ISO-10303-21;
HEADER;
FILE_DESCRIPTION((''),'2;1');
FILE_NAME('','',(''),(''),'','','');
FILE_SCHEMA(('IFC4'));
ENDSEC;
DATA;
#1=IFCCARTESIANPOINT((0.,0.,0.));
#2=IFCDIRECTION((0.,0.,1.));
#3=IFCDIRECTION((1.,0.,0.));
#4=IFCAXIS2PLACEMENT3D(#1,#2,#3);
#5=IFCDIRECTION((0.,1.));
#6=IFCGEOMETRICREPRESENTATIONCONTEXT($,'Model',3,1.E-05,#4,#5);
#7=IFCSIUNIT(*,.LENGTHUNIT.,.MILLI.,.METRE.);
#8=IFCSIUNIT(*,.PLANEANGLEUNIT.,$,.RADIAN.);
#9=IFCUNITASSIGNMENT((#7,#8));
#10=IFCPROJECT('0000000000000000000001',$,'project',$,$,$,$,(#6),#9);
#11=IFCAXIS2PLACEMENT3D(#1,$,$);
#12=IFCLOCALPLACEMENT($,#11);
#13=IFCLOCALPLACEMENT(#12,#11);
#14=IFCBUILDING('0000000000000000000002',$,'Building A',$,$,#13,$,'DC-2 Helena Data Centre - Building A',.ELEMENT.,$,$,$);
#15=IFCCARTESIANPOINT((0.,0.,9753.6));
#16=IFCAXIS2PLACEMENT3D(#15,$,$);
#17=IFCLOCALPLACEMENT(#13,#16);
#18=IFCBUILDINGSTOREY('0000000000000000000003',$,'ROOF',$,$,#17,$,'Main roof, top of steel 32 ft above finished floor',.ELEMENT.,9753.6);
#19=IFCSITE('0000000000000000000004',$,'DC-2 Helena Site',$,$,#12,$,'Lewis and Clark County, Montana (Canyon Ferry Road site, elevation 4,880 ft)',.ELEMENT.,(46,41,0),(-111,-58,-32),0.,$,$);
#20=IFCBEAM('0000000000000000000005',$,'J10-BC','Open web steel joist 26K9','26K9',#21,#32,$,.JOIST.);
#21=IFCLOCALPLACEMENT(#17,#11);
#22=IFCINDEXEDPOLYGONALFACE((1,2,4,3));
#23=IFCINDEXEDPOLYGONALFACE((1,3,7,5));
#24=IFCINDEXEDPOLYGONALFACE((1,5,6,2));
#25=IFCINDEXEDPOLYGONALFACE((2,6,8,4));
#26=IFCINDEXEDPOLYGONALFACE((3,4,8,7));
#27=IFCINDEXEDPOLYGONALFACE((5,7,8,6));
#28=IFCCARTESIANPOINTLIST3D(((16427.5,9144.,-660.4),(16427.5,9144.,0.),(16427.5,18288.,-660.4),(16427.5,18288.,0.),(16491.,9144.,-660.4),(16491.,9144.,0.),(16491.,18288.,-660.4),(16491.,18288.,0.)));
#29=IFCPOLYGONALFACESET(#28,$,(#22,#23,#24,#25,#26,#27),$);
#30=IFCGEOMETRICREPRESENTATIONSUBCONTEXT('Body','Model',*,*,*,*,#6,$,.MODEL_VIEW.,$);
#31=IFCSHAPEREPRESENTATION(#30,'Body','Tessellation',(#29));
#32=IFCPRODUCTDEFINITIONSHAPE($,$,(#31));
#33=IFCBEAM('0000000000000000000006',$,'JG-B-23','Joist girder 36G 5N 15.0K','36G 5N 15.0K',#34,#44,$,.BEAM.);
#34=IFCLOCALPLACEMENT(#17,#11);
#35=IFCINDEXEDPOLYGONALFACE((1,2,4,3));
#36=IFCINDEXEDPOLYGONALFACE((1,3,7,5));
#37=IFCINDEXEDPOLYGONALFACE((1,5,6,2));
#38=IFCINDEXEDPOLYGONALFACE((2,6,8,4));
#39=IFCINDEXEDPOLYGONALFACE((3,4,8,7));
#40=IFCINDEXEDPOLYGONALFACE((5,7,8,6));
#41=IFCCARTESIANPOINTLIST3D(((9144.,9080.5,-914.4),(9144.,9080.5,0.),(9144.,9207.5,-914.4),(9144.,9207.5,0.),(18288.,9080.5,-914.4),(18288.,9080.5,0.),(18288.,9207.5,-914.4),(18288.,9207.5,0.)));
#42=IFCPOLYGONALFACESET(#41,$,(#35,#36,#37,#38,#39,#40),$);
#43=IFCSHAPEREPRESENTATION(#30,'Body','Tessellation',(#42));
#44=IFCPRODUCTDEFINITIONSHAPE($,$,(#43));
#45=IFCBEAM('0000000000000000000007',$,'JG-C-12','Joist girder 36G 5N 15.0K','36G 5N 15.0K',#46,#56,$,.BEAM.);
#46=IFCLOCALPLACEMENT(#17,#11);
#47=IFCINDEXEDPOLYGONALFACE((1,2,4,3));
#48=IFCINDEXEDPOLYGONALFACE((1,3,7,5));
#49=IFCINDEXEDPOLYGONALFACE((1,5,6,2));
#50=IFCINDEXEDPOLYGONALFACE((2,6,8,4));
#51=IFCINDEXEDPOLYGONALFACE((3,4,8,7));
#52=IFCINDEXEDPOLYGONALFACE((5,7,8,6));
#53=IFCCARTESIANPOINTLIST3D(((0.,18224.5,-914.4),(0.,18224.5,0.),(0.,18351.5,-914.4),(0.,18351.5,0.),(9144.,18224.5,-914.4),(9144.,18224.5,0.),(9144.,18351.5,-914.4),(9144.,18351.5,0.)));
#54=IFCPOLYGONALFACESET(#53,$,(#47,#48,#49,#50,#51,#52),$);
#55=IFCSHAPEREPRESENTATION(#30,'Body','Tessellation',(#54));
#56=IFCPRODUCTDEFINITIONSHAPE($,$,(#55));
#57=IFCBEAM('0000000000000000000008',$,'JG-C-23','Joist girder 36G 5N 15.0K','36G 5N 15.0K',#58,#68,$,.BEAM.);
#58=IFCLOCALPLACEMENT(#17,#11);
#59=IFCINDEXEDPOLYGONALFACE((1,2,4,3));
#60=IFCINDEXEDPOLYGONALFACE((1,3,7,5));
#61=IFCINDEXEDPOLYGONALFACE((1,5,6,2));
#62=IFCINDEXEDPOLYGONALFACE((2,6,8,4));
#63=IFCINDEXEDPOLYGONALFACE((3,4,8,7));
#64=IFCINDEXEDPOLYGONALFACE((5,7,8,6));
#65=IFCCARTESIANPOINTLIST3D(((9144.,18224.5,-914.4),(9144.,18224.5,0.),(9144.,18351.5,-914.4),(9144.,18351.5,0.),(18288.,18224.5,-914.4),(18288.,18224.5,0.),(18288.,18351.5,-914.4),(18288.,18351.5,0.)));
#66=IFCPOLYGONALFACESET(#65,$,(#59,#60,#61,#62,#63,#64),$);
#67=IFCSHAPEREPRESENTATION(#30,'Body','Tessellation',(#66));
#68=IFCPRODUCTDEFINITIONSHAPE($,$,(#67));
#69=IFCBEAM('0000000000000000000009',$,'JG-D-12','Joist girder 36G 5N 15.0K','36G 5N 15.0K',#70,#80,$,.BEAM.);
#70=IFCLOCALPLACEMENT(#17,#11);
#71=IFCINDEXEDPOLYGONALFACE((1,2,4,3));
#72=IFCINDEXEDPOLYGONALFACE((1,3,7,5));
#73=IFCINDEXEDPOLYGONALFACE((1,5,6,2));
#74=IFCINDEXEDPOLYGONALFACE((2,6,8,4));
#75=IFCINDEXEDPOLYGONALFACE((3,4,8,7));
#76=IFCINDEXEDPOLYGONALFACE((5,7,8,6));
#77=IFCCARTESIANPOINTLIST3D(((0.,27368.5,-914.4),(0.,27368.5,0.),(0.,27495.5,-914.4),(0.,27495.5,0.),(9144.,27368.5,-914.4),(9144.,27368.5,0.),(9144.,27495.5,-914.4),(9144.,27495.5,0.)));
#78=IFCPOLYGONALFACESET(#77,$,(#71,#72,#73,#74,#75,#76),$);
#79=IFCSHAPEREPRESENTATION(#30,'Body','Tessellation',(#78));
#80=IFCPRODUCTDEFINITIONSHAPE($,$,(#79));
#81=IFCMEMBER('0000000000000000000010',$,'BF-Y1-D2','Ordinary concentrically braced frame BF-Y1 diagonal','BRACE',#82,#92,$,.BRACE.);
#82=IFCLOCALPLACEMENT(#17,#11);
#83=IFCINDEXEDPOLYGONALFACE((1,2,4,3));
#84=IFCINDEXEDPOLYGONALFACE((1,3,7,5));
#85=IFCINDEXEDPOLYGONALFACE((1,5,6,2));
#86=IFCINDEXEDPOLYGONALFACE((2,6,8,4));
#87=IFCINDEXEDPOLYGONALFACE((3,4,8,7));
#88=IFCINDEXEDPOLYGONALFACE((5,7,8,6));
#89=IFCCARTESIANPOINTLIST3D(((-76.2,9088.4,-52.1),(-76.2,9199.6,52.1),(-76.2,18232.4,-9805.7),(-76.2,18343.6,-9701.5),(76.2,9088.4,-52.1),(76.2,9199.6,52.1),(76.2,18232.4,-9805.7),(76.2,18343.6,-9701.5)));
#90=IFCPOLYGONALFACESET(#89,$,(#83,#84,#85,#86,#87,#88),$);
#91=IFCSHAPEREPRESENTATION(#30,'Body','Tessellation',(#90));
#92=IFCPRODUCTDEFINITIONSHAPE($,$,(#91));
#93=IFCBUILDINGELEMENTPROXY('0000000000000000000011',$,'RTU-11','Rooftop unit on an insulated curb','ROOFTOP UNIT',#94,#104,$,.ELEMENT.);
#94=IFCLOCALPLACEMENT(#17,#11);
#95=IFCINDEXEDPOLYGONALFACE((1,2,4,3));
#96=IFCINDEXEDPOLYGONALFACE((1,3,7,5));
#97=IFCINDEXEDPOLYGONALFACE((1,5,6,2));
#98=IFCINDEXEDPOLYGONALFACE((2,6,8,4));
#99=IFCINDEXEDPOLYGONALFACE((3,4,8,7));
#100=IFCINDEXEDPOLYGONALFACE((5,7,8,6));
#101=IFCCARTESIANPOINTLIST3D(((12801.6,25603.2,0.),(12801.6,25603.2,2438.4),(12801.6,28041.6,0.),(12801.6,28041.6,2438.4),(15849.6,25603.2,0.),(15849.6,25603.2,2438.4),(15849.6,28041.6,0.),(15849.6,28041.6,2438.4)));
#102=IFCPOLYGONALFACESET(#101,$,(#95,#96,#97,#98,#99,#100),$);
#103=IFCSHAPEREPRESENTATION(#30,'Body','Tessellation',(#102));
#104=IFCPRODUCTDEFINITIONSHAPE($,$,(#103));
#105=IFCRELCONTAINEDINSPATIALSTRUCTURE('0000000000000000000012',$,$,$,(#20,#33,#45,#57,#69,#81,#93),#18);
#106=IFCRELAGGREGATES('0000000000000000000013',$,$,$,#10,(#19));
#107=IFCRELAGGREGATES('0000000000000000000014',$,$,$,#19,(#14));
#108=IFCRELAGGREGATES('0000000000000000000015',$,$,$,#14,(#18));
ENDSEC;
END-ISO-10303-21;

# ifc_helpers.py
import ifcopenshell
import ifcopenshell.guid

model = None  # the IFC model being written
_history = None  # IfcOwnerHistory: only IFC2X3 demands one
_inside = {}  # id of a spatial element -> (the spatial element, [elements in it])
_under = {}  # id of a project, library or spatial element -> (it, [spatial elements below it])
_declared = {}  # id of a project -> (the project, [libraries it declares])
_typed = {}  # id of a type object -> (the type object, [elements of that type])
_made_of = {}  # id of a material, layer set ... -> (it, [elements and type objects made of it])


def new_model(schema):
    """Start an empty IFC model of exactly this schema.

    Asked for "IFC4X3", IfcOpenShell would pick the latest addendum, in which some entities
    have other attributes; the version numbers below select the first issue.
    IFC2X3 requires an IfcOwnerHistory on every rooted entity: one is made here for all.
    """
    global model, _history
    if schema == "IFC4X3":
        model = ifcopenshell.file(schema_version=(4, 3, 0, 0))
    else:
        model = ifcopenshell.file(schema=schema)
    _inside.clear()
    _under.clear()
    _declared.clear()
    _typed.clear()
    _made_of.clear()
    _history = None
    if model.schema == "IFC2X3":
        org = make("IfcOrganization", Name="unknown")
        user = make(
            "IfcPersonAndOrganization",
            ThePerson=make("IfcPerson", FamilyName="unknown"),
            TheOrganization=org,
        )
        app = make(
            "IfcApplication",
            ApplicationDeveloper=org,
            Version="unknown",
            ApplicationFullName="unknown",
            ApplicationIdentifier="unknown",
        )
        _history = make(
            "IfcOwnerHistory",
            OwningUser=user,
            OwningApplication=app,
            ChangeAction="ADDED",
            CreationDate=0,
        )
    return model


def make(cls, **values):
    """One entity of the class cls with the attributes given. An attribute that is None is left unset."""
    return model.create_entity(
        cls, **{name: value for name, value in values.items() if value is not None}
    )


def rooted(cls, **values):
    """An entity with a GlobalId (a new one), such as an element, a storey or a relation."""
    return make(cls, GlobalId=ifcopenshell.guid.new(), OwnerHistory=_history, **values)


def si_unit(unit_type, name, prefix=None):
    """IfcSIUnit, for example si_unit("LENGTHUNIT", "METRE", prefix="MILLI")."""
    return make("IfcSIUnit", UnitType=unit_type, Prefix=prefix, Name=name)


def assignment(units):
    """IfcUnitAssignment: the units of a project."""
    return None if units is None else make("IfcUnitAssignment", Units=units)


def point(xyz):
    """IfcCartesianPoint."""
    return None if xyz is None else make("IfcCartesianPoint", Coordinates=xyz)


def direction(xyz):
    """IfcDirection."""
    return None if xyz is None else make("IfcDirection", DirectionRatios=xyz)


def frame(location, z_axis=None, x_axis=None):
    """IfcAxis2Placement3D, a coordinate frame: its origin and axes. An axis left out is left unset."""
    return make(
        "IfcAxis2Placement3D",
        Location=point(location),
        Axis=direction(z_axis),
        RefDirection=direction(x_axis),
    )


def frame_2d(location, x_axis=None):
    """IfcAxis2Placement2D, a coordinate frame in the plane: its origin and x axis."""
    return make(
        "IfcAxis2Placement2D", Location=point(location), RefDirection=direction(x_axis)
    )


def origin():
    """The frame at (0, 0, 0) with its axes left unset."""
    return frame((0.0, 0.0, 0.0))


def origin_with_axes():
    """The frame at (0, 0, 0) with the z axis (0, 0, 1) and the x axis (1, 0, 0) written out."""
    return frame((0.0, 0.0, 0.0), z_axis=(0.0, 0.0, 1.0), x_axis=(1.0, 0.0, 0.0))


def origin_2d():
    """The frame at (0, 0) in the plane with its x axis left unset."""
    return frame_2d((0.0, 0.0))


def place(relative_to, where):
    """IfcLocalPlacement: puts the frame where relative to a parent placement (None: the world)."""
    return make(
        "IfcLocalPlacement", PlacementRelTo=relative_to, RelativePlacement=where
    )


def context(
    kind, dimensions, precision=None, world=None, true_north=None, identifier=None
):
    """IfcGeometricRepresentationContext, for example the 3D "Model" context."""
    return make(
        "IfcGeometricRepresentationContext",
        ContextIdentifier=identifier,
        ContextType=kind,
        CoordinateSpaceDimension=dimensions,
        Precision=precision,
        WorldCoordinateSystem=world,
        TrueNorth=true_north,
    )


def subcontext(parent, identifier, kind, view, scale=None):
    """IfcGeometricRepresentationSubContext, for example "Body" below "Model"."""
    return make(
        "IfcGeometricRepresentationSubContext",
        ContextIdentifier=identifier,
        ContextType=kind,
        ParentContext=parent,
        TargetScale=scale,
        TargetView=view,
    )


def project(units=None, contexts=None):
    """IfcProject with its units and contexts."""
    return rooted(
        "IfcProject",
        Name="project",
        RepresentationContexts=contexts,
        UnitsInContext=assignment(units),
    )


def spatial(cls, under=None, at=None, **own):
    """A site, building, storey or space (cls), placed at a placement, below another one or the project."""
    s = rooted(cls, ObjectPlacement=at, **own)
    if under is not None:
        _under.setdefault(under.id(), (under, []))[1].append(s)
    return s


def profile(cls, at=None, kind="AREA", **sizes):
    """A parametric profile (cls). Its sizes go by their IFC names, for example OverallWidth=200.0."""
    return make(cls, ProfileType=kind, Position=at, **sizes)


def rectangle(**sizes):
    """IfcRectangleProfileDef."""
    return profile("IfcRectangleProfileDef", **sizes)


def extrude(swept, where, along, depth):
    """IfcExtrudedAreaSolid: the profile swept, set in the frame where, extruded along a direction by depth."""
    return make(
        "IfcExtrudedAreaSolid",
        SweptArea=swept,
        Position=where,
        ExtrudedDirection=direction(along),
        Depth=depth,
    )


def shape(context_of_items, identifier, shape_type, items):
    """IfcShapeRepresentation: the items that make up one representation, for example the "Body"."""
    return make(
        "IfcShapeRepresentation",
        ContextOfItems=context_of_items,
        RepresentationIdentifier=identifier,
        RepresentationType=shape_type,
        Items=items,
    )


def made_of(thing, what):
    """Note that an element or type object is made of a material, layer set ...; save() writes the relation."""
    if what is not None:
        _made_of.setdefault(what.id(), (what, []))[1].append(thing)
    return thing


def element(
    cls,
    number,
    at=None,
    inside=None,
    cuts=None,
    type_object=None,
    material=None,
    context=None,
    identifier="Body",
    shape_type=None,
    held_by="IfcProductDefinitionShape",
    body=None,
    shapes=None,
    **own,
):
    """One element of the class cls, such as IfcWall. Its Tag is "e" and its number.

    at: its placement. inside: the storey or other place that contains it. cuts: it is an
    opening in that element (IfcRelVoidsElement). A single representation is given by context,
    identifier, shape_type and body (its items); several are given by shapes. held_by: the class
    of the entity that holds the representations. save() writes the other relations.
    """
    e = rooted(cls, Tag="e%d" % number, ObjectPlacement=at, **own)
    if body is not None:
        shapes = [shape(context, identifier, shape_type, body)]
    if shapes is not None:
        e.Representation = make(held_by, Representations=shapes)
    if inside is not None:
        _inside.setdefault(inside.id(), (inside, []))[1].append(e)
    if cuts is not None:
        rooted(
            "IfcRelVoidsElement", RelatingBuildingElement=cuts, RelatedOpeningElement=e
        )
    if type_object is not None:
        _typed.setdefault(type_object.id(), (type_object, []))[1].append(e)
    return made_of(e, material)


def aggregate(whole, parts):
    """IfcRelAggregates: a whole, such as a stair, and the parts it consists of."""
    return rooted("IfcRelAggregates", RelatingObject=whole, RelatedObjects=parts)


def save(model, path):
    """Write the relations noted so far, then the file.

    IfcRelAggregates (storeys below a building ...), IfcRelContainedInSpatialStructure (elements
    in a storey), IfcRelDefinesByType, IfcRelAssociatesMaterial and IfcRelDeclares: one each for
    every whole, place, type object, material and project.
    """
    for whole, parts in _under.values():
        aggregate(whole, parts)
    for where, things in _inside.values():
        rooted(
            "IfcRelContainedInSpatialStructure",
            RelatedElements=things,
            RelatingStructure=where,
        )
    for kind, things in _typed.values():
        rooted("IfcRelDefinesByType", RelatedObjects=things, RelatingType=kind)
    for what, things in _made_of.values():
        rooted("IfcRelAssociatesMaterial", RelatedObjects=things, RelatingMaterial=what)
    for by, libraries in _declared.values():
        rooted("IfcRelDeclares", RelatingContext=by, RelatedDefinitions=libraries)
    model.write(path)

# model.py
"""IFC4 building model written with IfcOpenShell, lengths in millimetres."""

from ifc_helpers import new_model, si_unit, direction, frame, origin, origin_with_axes, origin_2d, place, context, subcontext, project, spatial, rectangle, extrude, element, save


model = new_model("IFC4")

# Units and contexts
model_context = context("Model", 3, precision=1e-05, world=origin_with_axes(), true_north=direction((0.0, 1.0)))
body_context = subcontext(model_context, "Body", "Model", "MODEL_VIEW")
ifc_project = project(units=[si_unit("LENGTHUNIT", "METRE", prefix="MILLI"), si_unit("PLANEANGLEUNIT", "RADIAN")], contexts=[model_context])

# Site, building, storey
site_placement = place(None, origin())
site = spatial("IfcSite", under=ifc_project, at=site_placement, Name="DC-2 Helena Site", LongName="Lewis and Clark County, Montana (Canyon Ferry Road site, elevation 4,880 ft)", CompositionType="ELEMENT", RefLatitude=(46, 41, 0), RefLongitude=(-111, -58, -32), RefElevation=0.0)
building_placement = place(site_placement, origin())
building = spatial("IfcBuilding", under=site, at=building_placement, Name="Building A", LongName="DC-2 Helena Data Centre - Building A", CompositionType="ELEMENT")
storey_placement = place(building_placement, frame((0.0, 0.0, 9753.6)))
storey = spatial("IfcBuildingStorey", under=building, at=storey_placement, Name="ROOF", LongName="Main roof, top of steel 32 ft above finished floor", CompositionType="ELEMENT", Elevation=9753.6)

# Shared definitions
placement_1 = place(storey_placement, frame((0.0, 18288.0, -9753.6)))

# Beams
placement_2 = place(storey_placement, frame((0.0, 18288.0, 0.0)))
placement_3 = place(storey_placement, frame((0.0, 27432.0, 0.0)))
placement_4 = place(storey_placement, frame((9144.0, 9144.0, 0.0)))
placement_5 = place(storey_placement, frame((9144.0, 18288.0, 0.0)))
for number, where, name in (
    (1, (16459.2, 9144.0, 0.0), "J10-BC"),
):
    element("IfcBeam", number, at=place(storey_placement, frame(where)), inside=storey, Name=name, Description="Open web steel joist 26K9", ObjectType="26K9", PredefinedType="JOIST", context=body_context, shape_type="SweptSolid", body=[
        extrude(rectangle(XDim=63.5, YDim=660.4, at=origin_2d()), frame((0.0, 0.0, -330.2), z_axis=(0.0, 1.0, 0.0), x_axis=(1.0, 0.0, 0.0)), (0.0, 0.0, 1.0), 9144.0),
    ])
element("IfcBeam", 2, at=placement_4, inside=storey, Name="JG-B-23", Description="Joist girder 36G 5N 15.0K", ObjectType="36G 5N 15.0K", PredefinedType="BEAM", context=body_context, shape_type="SweptSolid", body=[
    extrude(rectangle(XDim=127.0, YDim=914.4, at=origin_2d()), frame((0.0, 0.0, -457.2), z_axis=(1.0, 0.0, 0.0), x_axis=(0.0, 1.0, 0.0)), (0.0, 0.0, 1.0), 9144.0),
])
element("IfcBeam", 3, at=placement_2, inside=storey, Name="JG-C-12", Description="Joist girder 36G 5N 15.0K", ObjectType="36G 5N 15.0K", PredefinedType="BEAM", context=body_context, shape_type="SweptSolid", body=[
    extrude(rectangle(XDim=127.0, YDim=914.4, at=origin_2d()), frame((0.0, 0.0, -457.2), z_axis=(1.0, 0.0, 0.0), x_axis=(0.0, 1.0, 0.0)), (0.0, 0.0, 1.0), 9144.0),
])
element("IfcBeam", 4, at=placement_5, inside=storey, Name="JG-C-23", Description="Joist girder 36G 5N 15.0K", ObjectType="36G 5N 15.0K", PredefinedType="BEAM", context=body_context, shape_type="SweptSolid", body=[
    extrude(rectangle(XDim=127.0, YDim=914.4, at=origin_2d()), frame((0.0, 0.0, -457.2), z_axis=(1.0, 0.0, 0.0), x_axis=(0.0, 1.0, 0.0)), (0.0, 0.0, 1.0), 9144.0),
])
element("IfcBeam", 5, at=placement_3, inside=storey, Name="JG-D-12", Description="Joist girder 36G 5N 15.0K", ObjectType="36G 5N 15.0K", PredefinedType="BEAM", context=body_context, shape_type="SweptSolid", body=[
    extrude(rectangle(XDim=127.0, YDim=914.4, at=origin_2d()), frame((0.0, 0.0, -457.2), z_axis=(1.0, 0.0, 0.0), x_axis=(0.0, 1.0, 0.0)), (0.0, 0.0, 1.0), 9144.0),
])

# Member
element("IfcMember", 6, at=placement_1, inside=storey, Name="BF-Y1-D2", Description="Ordinary concentrically braced frame BF-Y1 diagonal", ObjectType="BRACE", PredefinedType="BRACE", context=body_context, shape_type="SweptSolid", body=[
    extrude(rectangle(XDim=152.4, YDim=152.4, at=origin_2d()), frame((0.0, 0.0, 0.0), z_axis=(0.0, -0.683941, 0.729537), x_axis=(1.0, 0.0, 0.0)), (0.0, 0.0, 1.0), 13369.6),
])

# Building element proxy
proxy_placement = place(storey_placement, frame((14325.6, 26822.4, 0.0)))
element("IfcBuildingElementProxy", 7, at=proxy_placement, inside=storey, Name="RTU-11", Description="Rooftop unit on an insulated curb", ObjectType="ROOFTOP UNIT", PredefinedType="ELEMENT", context=body_context, shape_type="SweptSolid", body=[
    extrude(rectangle(XDim=3048.0, YDim=2438.4, at=origin_2d()), origin(), (0.0, 0.0, 1.0), 2438.4),
])

save(model, "model.ifc")
